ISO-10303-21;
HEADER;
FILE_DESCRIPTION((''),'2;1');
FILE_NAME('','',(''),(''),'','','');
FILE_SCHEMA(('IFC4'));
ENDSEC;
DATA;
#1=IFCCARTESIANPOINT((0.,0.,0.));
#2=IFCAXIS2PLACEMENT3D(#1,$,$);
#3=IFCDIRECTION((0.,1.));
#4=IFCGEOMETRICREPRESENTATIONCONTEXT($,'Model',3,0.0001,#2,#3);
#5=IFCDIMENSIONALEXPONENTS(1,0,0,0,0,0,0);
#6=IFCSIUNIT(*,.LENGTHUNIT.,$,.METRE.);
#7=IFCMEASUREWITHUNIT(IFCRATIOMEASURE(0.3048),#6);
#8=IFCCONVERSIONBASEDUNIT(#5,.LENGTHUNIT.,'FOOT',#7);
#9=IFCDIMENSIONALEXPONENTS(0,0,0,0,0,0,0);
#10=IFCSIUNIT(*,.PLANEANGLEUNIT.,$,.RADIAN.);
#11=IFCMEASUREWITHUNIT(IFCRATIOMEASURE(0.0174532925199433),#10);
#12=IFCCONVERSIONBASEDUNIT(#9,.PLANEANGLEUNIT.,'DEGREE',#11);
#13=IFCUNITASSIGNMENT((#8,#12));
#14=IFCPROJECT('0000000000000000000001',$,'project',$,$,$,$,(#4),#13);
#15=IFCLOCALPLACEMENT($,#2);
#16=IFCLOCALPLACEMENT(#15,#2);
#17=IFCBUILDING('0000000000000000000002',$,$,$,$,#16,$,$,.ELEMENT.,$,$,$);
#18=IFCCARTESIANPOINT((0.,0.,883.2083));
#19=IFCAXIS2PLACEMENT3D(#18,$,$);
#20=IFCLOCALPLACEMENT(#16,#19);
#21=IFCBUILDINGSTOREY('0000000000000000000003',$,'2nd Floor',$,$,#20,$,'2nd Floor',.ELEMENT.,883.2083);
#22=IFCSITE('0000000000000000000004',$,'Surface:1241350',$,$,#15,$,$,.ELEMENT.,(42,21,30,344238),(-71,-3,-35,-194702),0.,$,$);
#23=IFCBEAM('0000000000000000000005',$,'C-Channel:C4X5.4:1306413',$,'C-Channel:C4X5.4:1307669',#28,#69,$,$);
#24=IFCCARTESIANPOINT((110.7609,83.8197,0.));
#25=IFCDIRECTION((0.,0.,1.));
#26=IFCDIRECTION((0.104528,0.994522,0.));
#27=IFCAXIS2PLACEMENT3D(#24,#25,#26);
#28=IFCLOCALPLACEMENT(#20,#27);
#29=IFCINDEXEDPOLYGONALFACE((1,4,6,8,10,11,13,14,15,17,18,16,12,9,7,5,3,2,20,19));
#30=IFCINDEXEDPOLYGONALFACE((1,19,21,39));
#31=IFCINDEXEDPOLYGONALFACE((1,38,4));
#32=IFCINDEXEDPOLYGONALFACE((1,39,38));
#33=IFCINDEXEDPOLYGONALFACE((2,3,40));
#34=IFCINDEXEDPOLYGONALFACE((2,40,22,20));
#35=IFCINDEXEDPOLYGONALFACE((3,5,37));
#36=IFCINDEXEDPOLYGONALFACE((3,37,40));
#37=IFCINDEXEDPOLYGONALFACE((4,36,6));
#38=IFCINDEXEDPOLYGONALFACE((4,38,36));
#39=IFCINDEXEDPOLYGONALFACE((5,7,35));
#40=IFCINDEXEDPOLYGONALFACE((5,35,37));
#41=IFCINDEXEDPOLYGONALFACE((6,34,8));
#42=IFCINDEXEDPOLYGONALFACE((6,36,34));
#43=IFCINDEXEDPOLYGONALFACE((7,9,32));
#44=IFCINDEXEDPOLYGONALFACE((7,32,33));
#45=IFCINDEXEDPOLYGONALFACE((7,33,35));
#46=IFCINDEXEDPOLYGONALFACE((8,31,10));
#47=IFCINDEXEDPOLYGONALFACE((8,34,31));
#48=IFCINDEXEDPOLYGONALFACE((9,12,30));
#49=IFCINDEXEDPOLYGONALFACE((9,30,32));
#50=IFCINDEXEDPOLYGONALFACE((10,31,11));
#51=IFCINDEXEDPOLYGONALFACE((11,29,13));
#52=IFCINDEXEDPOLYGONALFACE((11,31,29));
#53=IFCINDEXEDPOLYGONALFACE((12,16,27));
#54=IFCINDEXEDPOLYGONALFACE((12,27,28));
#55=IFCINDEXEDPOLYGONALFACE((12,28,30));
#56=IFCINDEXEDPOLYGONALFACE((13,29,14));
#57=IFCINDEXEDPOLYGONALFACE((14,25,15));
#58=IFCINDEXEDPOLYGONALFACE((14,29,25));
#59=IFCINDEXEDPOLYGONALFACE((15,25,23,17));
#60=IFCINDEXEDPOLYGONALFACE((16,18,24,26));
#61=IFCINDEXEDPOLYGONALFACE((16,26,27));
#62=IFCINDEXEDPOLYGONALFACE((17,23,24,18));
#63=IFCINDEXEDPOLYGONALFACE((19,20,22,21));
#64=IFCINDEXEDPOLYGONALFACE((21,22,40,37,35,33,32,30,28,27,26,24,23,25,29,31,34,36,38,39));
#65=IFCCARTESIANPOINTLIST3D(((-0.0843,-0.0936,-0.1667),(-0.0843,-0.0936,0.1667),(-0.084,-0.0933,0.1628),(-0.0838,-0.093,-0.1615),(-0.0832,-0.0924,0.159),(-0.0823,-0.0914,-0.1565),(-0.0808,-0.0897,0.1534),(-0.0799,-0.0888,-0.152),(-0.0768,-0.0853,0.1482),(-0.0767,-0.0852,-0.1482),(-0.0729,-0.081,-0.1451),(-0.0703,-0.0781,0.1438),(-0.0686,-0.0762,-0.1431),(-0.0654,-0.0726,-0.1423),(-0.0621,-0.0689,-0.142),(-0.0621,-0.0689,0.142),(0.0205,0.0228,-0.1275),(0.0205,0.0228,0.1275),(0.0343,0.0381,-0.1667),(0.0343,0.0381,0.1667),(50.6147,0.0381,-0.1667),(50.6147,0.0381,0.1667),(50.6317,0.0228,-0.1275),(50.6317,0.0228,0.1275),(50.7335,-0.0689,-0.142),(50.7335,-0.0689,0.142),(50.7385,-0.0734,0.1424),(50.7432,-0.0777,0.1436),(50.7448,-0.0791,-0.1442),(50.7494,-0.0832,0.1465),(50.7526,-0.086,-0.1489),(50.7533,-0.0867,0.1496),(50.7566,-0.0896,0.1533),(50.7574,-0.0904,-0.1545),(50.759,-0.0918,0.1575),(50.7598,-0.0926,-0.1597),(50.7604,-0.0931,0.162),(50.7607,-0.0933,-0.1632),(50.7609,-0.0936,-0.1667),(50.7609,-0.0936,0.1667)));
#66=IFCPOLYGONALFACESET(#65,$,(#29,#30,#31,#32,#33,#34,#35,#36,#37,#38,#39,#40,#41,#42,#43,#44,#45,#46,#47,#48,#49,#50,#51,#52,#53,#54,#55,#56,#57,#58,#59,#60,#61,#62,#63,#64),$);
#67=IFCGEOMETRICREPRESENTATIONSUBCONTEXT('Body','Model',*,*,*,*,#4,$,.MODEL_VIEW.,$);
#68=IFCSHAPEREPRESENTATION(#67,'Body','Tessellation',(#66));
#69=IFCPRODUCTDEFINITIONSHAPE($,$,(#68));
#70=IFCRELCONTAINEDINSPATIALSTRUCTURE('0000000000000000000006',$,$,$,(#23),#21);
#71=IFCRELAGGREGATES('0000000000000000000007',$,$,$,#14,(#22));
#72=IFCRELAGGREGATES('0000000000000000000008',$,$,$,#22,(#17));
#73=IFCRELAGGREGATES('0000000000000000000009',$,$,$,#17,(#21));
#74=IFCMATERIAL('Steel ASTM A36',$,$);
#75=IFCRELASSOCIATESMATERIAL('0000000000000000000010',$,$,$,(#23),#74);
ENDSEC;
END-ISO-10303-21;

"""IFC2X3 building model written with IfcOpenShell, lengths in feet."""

from ifc_helpers import new_model, entity, si_unit, converted_unit, direction, frame, frame_2d, origin, place, context, subcontext, project, spatial, polyline, circle_curve, parameter, trimmed, segment, composite_curve, outline, extrude, clip, halfspace, material, element, save


model = new_model("IFC2X3")

# Units and contexts
model_context = context("Model", 3, precision=0.0001, world=origin(), true_north=direction((0.0, 1.0)))
body_context = subcontext(model_context, "Body", "Model", "MODEL_VIEW")
ifc_project = project(units=[converted_unit("LENGTHUNIT", "FOOT", entity("IfcRatioMeasure", 0.3048), si_unit("LENGTHUNIT", "METRE"), dimensions=[1, 0, 0, 0, 0, 0, 0]), converted_unit("PLANEANGLEUNIT", "DEGREE", entity("IfcRatioMeasure", 0.0174532925199433), si_unit("PLANEANGLEUNIT", "RADIAN"), dimensions=[0, 0, 0, 0, 0, 0, 0])], contexts=[model_context])

# Site, building, storey
site_placement = place(None, origin())
site = spatial("IfcSite", under=ifc_project, at=site_placement, Name="Surface:1241350", CompositionType="ELEMENT", RefLatitude=(42, 21, 30, 344238), RefLongitude=(-71, -3, -35, -194702), RefElevation=0.0)
building_placement = place(site_placement, origin())
building = spatial("IfcBuilding", under=site, at=building_placement, CompositionType="ELEMENT")
storey_placement = place(building_placement, frame((0.0, 0.0, 883.2083)))
storey = spatial("IfcBuildingStorey", under=building, at=storey_placement, Name="2nd Floor", LongName="2nd Floor", CompositionType="ELEMENT", Elevation=883.2083)

# Beam
ifc_material_1 = material(Name="Steel ASTM A36")
beam_1_placement = place(storey_placement, frame((110.7609, 83.8197, 0.0), z_axis=(0.0, 0.0, 1.0), x_axis=(0.104528, 0.994522, 0.0)))
element("IfcBeam", 1, at=beam_1_placement, inside=storey, material=ifc_material_1, Name="C-Channel:C4X5.4:1306413", ObjectType="C-Channel:C4X5.4:1307669", context=body_context, shape_type="Clipping", body=[
    clip(clip(extrude(outline(composite_curve([segment(polyline([(-0.0682, -0.1667), (0.0635, -0.1667)]), True, "CONTINUOUS"), segment(polyline([(0.0635, -0.1667), (0.0635, 0.1667)]), True, "CONTINUOUS"), segment(polyline([(0.0635, 0.1667), (-0.0682, 0.1667)]), True, "CONTINUOUS"), segment(trimmed(circle_curve(frame_2d((-0.0435, 0.1667), x_axis=(-1.0, 0.0)), 0.0247), [parameter(0.0)], [parameter(90.0)], True, "PARAMETER"), True, "CONTINUOUS"), segment(polyline([(-0.0435, 0.142), (0.0482, 0.1275)]), True, "CONTINUOUS"), segment(polyline([(0.0482, 0.1275), (0.0482, -0.1275)]), True, "CONTINUOUS"), segment(polyline([(0.0482, -0.1275), (-0.0435, -0.142)]), True, "CONTINUOUS"), segment(trimmed(circle_curve(frame_2d((-0.0435, -0.1667), x_axis=(0.0, 1.0)), 0.0247), [parameter(0.0)], [parameter(90.0)], True, "PARAMETER"), True, "CONTINUOUS")], self_intersect=False)), frame((-0.0843, -0.0254, 0.0), z_axis=(1.0, 0.0, 0.0), x_axis=(0.0, 1.0, 0.0)), (0.0, 0.0, 1.0), 50.8452), halfspace(frame((0.0343, 0.0381, 0.0), z_axis=(-0.743145, 0.669131, 0.0), x_axis=(-0.669131, -0.743145, 0.0)), False)), halfspace(frame((50.6147, 0.0381, 0.0), z_axis=(0.669131, 0.743145, 0.0), x_axis=(0.743145, -0.669131, 0.0)), False)),
])

save(model, "model.ifc")
